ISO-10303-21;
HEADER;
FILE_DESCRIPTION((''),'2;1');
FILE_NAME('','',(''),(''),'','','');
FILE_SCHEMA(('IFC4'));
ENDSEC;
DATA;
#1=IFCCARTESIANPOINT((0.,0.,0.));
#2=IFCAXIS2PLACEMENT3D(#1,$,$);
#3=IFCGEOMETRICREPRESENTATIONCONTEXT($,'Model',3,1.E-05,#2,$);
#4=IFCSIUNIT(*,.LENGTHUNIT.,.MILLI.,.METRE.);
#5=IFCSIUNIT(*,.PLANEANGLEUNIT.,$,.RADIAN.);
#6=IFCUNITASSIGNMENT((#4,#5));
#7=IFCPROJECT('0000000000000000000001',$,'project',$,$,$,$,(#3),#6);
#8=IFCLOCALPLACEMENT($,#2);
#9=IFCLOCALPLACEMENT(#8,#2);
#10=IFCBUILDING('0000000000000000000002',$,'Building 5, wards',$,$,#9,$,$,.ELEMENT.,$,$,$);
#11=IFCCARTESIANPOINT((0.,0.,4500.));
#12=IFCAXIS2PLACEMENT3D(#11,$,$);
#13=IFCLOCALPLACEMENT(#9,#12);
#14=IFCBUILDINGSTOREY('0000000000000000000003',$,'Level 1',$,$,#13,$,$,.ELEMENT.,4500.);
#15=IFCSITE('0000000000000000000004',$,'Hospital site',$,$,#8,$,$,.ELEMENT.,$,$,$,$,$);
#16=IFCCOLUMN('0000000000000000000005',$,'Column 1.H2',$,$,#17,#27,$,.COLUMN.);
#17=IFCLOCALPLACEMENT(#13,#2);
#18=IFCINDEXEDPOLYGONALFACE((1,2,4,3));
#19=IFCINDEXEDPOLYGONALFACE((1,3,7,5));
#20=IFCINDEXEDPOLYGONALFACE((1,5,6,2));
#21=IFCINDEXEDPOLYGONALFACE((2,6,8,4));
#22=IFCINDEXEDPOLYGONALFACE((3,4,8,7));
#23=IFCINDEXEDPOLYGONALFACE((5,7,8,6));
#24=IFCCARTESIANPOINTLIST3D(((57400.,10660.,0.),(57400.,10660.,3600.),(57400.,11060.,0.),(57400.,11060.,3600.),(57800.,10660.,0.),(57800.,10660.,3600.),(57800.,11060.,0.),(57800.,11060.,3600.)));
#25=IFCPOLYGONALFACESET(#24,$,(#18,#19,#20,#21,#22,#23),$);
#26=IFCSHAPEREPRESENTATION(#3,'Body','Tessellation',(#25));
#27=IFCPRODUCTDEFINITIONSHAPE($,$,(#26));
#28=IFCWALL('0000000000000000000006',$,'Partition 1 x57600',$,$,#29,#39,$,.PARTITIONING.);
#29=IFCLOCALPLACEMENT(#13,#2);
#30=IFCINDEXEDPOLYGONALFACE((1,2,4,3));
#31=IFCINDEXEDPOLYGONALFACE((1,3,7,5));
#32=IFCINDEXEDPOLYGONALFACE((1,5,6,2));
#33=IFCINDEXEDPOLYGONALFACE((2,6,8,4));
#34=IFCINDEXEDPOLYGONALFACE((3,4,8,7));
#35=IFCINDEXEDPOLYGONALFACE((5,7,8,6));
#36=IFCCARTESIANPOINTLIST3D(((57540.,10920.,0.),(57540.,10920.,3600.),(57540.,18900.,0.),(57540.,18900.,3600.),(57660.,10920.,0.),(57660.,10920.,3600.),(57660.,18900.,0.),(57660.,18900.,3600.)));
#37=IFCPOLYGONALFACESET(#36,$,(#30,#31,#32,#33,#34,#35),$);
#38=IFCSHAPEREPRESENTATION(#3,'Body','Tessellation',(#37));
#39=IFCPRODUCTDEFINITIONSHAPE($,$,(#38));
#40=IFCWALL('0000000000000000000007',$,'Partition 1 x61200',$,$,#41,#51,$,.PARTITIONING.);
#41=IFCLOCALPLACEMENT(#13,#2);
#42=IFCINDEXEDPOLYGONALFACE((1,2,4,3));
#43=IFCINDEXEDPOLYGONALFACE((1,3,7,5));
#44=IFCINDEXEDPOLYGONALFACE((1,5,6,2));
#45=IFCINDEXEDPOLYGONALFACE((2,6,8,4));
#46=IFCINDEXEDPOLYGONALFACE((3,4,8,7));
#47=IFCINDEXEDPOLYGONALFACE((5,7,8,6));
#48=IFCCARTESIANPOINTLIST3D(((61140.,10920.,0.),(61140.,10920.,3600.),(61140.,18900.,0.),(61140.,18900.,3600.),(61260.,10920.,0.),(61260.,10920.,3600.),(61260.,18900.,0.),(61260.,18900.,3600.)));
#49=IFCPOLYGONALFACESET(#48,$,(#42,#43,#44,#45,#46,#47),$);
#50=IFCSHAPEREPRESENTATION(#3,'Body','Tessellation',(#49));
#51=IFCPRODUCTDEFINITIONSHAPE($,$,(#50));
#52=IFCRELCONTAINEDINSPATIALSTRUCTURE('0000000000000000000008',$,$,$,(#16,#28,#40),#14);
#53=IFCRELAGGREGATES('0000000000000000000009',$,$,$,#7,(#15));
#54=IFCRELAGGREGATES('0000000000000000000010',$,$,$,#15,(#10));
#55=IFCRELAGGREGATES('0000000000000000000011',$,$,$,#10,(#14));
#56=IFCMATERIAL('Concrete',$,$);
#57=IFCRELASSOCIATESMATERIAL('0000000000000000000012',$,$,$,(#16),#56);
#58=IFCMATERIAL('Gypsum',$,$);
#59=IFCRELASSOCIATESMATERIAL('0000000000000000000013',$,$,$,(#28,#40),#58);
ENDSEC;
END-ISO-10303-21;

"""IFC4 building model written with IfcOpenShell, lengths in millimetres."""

from ifc_helpers import new_model, si_unit, frame, frame_2d, origin, origin_2d, place, context, project, spatial, rectangle, extrude, material, element, save


model = new_model("IFC4")

# Units and contexts
model_context = context("Model", 3, precision=1e-05, world=origin())
ifc_project = project(units=[si_unit("LENGTHUNIT", "METRE", prefix="MILLI"), si_unit("PLANEANGLEUNIT", "RADIAN")], contexts=[model_context])

# Site, building, storey
site_placement = place(None, origin())
site = spatial("IfcSite", under=ifc_project, at=site_placement, Name="Hospital site", CompositionType="ELEMENT")
building_placement = place(site_placement, origin())
building = spatial("IfcBuilding", under=site, at=building_placement, Name="Building 5, wards", CompositionType="ELEMENT")
storey_placement = place(building_placement, frame((0.0, 0.0, 4500.0)))
storey = spatial("IfcBuildingStorey", under=building, at=storey_placement, Name="Level 1", CompositionType="ELEMENT", Elevation=4500.0)

# Column
ifc_material_1 = material(Name="Concrete")
column_placement = place(storey_placement, frame((57600.0, 10860.0, 0.0)))
element("IfcColumn", 1, at=column_placement, inside=storey, material=ifc_material_1, Name="Column 1.H2", PredefinedType="COLUMN", context=model_context, shape_type="SweptSolid", body=[
    extrude(rectangle(XDim=400.0, YDim=400.0, at=origin_2d()), origin(), (0.0, 0.0, 1.0), 3600.0),
])

# Walls
ifc_material_2 = material(Name="Gypsum")
for number, where, x_axis, name in (
    (2, (57660.0, 10920.0, 0.0), (0.0, 1.0, 0.0), "Partition 1 x57600"),
    (3, (61260.0, 10920.0, 0.0), (0.0, 1.0, 0.0), "Partition 1 x61200"),
):
    element("IfcWall", number, at=place(storey_placement, frame(where, x_axis=x_axis)), inside=storey, material=ifc_material_2, Name=name, PredefinedType="PARTITIONING", context=model_context, shape_type="SweptSolid", body=[
        extrude(rectangle(XDim=7980.0, YDim=120.0, at=frame_2d((3990.0, 60.0))), origin(), (0.0, 0.0, 1.0), 3600.0),
    ])

save(model, "model.ifc")
